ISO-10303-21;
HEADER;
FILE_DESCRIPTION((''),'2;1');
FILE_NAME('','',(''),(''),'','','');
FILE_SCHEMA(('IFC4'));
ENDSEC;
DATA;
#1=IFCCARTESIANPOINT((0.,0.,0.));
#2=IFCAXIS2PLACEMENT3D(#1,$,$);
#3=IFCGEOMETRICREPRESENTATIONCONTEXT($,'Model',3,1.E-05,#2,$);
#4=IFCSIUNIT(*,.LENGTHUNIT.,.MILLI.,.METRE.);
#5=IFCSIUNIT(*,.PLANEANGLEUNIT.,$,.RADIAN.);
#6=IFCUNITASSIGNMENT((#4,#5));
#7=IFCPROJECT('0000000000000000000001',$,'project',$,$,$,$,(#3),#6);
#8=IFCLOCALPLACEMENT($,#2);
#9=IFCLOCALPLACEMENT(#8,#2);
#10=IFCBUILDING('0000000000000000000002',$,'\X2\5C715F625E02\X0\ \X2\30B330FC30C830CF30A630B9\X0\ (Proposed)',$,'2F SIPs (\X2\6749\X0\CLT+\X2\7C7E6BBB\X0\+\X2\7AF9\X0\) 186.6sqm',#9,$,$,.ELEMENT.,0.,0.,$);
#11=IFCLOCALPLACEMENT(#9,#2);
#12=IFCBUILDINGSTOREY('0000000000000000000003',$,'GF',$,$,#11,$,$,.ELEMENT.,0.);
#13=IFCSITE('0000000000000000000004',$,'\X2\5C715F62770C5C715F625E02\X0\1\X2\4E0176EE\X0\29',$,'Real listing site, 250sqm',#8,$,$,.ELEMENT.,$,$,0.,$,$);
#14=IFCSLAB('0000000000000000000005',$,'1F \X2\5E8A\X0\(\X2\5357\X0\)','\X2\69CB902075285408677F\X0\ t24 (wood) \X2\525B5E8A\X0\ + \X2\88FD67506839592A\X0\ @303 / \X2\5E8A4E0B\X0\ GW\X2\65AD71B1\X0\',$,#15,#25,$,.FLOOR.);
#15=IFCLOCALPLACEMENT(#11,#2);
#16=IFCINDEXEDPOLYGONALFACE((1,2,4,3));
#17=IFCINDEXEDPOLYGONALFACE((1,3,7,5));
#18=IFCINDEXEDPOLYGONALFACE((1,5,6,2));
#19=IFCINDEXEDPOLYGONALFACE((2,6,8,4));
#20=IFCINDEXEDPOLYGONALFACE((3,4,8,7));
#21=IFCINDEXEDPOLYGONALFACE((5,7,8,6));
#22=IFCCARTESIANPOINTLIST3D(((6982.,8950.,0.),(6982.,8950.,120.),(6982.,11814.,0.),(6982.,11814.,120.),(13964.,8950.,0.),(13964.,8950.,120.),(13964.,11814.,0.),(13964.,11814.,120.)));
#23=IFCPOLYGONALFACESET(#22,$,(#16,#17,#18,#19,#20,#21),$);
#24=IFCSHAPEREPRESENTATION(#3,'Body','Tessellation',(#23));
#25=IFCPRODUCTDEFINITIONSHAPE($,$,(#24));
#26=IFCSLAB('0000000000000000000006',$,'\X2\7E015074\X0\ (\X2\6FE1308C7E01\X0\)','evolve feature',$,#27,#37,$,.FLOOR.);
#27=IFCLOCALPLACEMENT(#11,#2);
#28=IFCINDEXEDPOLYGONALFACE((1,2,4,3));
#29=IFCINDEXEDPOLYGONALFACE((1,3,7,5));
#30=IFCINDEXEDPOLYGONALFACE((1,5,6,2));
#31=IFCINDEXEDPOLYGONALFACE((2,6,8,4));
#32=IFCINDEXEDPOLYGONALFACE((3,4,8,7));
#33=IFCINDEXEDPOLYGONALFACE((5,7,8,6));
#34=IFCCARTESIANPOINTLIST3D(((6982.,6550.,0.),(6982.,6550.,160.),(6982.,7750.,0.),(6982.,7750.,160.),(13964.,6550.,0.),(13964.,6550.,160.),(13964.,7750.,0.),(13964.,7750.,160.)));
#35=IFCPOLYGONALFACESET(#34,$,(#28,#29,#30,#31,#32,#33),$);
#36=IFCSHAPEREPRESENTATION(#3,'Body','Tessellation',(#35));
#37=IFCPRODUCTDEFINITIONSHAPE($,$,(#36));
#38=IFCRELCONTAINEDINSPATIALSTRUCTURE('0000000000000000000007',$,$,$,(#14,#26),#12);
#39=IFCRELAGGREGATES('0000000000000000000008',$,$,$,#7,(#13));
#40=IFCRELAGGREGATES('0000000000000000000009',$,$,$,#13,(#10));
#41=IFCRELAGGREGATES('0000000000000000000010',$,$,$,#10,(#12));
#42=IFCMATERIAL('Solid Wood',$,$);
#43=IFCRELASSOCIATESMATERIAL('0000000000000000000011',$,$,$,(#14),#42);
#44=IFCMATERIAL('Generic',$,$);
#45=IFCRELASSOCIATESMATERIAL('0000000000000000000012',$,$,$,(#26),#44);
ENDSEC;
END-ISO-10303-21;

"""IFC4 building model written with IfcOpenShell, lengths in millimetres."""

from ifc_helpers import new_model, si_unit, frame, frame_2d, origin, place, context, project, spatial, rectangle, extrude, material, element, save


model = new_model("IFC4")

# Units and contexts
model_context = context("Model", 3, precision=1e-05, world=origin())
ifc_project = project(units=[si_unit("LENGTHUNIT", "METRE", prefix="MILLI"), si_unit("PLANEANGLEUNIT", "RADIAN")], contexts=[model_context])

# Site, building, storey
site_placement = place(None, origin())
site = spatial("IfcSite", under=ifc_project, at=site_placement, Name="山形県山形市1丁目29", ObjectType="Real listing site, 250sqm", CompositionType="ELEMENT", RefElevation=0.0)
building_placement = place(site_placement, origin())
building = spatial("IfcBuilding", under=site, at=building_placement, Name="山形市 コートハウス (Proposed)", ObjectType="2F SIPs (杉CLT+籾殻+竹) 186.6sqm", CompositionType="ELEMENT", ElevationOfRefHeight=0.0, ElevationOfTerrain=0.0)
storey_placement = place(building_placement, origin())
storey = spatial("IfcBuildingStorey", under=building, at=storey_placement, Name="GF", CompositionType="ELEMENT", Elevation=0.0)

# Slabs
ifc_material_1 = material(Name="Solid Wood")
slab_1_placement = place(storey_placement, frame((3491.0, 4475.0, 0.0)))
element("IfcSlab", 1, at=slab_1_placement, inside=storey, material=ifc_material_1, Name="1F 床(南)", Description="構造用合板 t24 (wood) 剛床 + 製材根太 @303 / 床下 GW断熱", PredefinedType="FLOOR", context=model_context, shape_type="SweptSolid", body=[
    extrude(rectangle(XDim=6982.0, YDim=2864.0, at=frame_2d((3491.0, 1432.0))), frame((3491.0, 4475.0, 0.0)), (0.0, 0.0, 1.0), 120.0),
])
ifc_material_2 = material(Name="Generic")
slab_2_placement = place(storey_placement, frame((3491.0, 3275.0, 0.0)))
element("IfcSlab", 2, at=slab_2_placement, inside=storey, material=ifc_material_2, Name="縁側 (濡れ縁)", Description="evolve feature", PredefinedType="FLOOR", context=model_context, shape_type="SweptSolid", body=[
    extrude(rectangle(XDim=6982.0, YDim=1200.0, at=frame_2d((3491.0, 600.0))), frame((3491.0, 3275.0, 0.0)), (0.0, 0.0, 1.0), 160.0),
])

save(model, "model.ifc")
